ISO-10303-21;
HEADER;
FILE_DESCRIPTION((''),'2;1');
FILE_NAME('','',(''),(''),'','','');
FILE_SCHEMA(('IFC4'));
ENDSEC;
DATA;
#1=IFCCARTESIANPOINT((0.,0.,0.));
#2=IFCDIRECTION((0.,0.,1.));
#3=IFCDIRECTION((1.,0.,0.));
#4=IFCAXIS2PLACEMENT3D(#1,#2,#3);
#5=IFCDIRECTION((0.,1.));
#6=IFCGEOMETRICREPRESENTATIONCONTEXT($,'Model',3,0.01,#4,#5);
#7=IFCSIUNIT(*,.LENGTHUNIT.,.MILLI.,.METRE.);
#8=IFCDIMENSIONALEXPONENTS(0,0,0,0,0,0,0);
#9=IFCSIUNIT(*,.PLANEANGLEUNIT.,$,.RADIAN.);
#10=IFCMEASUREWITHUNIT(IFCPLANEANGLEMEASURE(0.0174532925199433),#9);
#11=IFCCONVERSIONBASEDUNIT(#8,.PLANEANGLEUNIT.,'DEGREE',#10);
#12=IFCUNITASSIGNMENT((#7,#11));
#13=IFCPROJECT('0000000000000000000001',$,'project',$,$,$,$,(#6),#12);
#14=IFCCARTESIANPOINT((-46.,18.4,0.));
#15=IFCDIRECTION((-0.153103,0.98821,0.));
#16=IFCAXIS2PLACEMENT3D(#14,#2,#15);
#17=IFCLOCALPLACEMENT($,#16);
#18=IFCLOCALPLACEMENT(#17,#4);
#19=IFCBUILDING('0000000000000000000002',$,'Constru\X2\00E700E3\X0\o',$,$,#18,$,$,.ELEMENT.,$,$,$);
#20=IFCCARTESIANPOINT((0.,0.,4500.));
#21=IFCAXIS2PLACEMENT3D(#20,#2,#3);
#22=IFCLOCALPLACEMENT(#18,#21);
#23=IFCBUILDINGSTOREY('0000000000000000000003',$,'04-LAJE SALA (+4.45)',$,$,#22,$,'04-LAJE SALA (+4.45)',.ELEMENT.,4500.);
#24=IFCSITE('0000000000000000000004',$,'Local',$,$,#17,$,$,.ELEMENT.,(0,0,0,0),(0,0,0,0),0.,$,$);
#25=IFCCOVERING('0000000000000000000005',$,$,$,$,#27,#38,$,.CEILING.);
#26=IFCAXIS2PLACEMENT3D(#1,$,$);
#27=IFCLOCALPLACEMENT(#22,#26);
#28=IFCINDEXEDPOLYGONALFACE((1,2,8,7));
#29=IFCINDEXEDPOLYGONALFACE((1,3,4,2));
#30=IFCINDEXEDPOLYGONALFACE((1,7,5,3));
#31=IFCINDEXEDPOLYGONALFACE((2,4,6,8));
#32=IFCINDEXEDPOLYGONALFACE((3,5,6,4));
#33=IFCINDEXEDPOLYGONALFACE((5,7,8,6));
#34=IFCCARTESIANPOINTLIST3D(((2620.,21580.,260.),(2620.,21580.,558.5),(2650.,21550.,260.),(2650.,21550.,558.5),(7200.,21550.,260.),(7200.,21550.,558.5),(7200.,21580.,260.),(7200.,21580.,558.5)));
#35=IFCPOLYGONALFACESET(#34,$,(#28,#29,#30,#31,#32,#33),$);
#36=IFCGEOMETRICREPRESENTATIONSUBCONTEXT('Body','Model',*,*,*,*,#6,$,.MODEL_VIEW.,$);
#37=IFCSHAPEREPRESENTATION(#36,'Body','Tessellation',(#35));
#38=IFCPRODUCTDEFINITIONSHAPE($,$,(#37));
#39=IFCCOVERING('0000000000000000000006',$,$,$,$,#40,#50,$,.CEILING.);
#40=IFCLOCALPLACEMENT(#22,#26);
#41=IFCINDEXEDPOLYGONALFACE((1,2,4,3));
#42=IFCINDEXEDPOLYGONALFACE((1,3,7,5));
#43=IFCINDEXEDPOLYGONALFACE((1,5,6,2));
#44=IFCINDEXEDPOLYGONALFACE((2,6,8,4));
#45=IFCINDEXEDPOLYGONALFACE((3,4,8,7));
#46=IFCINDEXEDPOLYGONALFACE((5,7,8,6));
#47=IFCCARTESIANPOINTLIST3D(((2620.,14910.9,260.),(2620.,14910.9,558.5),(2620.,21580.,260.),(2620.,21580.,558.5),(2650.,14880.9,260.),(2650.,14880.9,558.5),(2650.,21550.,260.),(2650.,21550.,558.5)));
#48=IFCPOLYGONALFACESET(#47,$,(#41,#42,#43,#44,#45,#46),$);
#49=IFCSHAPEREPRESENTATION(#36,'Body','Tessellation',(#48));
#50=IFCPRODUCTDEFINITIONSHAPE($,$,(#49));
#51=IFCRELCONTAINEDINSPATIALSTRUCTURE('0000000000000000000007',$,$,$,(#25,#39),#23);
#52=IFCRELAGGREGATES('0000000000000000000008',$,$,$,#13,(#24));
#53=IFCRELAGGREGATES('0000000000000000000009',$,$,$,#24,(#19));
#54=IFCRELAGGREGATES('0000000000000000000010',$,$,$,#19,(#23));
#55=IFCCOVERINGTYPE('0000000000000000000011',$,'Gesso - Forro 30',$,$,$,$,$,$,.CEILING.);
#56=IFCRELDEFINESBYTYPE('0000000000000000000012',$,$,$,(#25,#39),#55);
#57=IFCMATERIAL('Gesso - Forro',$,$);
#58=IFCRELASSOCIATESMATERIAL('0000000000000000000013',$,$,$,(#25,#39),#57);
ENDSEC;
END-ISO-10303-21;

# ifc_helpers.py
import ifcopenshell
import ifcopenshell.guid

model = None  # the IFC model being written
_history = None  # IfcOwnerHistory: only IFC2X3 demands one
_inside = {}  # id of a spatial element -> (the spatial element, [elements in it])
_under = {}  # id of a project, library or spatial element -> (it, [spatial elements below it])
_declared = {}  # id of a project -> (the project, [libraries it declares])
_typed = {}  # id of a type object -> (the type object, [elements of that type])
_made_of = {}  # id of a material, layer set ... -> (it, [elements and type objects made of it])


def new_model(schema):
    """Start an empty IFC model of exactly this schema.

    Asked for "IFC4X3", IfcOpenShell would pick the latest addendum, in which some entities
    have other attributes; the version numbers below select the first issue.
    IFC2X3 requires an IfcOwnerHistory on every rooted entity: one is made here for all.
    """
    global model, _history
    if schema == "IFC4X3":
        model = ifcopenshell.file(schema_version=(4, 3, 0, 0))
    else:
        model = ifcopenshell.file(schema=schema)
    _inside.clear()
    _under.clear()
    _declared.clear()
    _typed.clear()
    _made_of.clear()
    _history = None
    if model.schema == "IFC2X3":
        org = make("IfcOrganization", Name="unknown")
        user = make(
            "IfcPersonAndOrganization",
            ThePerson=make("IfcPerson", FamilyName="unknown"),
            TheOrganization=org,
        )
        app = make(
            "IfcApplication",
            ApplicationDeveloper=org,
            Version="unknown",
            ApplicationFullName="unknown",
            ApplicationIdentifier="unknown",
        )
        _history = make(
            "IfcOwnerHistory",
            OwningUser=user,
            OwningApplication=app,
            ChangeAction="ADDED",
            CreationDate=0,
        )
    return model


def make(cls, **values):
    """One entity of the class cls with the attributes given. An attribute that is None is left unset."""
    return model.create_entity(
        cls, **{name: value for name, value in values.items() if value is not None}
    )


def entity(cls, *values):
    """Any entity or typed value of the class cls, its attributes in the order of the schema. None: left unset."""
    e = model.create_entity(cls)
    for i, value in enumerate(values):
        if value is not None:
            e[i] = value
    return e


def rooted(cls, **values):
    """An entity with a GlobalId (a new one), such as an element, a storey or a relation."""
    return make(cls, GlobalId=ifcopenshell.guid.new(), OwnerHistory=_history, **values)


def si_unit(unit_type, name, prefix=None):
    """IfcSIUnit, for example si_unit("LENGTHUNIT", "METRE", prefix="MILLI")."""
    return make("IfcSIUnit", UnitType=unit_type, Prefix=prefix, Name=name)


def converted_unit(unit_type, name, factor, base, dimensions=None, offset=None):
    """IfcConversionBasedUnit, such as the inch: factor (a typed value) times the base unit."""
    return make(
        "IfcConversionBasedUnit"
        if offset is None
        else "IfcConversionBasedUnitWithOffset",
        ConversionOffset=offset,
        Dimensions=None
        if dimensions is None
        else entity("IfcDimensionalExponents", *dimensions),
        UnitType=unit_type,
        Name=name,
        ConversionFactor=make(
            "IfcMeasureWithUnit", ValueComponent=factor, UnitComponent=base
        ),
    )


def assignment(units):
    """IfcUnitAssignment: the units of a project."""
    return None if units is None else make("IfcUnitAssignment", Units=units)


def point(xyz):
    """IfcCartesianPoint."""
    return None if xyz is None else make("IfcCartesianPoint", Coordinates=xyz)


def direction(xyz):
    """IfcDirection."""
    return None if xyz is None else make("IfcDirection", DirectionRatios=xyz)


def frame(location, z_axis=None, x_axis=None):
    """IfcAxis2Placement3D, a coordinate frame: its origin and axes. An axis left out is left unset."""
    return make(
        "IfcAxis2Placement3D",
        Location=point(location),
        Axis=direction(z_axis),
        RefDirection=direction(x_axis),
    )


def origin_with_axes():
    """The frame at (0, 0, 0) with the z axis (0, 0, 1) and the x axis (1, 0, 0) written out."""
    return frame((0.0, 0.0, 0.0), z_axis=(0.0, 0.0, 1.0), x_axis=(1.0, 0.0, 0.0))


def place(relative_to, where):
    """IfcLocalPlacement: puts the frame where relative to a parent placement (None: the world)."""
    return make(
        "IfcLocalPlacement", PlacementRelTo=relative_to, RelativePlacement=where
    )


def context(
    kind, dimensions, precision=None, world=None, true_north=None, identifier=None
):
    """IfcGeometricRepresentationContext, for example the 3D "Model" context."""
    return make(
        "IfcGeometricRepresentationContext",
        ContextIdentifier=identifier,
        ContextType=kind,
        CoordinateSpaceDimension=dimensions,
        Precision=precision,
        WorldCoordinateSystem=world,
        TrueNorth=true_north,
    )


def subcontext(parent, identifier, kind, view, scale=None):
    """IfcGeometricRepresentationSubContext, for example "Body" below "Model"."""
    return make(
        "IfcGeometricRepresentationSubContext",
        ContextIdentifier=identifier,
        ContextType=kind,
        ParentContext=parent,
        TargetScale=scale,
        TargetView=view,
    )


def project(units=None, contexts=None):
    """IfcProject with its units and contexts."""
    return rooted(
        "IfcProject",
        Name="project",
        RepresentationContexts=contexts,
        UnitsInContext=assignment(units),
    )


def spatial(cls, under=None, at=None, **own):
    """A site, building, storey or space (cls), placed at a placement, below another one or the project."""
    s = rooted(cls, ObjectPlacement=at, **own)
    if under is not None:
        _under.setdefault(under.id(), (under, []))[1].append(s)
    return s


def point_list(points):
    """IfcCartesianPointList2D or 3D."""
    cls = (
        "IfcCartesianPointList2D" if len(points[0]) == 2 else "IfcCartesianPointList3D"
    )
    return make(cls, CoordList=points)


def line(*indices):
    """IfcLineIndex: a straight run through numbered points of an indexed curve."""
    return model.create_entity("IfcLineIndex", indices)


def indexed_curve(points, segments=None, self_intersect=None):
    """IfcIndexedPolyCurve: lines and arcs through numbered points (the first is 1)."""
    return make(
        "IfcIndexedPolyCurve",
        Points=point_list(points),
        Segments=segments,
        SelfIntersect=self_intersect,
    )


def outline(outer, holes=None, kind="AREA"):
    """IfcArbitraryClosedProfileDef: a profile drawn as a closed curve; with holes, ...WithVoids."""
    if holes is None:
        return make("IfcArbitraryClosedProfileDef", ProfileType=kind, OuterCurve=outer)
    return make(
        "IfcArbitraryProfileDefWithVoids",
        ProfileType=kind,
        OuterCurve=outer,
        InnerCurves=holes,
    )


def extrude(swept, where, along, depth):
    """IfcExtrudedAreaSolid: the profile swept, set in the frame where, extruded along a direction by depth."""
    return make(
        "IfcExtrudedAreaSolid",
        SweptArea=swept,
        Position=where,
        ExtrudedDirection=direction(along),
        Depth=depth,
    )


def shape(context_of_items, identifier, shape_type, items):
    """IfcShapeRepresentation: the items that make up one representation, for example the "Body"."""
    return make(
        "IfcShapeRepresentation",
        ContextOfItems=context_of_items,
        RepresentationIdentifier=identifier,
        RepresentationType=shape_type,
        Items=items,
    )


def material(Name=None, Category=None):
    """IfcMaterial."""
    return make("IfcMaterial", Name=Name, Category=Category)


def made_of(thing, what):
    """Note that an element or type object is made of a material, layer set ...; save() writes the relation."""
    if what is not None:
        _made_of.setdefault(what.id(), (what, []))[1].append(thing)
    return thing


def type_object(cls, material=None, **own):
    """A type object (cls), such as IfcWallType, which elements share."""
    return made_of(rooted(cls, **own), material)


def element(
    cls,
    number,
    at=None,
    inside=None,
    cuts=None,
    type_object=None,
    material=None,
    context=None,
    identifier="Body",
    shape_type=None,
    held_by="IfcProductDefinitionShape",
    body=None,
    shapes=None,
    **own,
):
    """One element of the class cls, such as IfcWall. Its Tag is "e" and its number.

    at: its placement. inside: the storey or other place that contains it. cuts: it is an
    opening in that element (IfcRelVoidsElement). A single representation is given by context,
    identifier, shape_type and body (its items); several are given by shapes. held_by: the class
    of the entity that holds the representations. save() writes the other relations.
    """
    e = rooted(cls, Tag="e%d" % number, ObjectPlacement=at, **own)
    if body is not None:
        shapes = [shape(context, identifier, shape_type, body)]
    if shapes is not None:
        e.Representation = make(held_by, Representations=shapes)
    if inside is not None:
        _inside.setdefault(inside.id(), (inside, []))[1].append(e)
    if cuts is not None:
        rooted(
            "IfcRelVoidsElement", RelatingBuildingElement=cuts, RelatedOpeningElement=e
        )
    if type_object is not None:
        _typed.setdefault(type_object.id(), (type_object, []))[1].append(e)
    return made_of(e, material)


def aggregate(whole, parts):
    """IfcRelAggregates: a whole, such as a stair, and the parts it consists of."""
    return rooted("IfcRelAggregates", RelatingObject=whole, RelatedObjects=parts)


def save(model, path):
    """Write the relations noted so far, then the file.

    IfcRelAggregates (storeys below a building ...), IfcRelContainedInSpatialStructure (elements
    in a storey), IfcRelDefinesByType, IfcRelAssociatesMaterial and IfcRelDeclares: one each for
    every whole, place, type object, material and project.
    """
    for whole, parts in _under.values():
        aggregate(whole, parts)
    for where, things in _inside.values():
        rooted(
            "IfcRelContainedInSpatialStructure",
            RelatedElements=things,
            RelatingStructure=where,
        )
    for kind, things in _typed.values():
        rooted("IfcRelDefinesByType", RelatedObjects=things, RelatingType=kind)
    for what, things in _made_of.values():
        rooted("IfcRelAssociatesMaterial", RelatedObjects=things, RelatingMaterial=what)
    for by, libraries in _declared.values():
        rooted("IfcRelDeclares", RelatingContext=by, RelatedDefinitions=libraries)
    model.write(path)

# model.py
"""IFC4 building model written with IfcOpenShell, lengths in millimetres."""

from ifc_helpers import new_model, entity, si_unit, converted_unit, direction, frame, origin_with_axes, place, context, subcontext, project, spatial, line, indexed_curve, outline, extrude, material, type_object, element, save


model = new_model("IFC4")

# Units and contexts
model_context = context("Model", 3, precision=0.01, world=origin_with_axes(), true_north=direction((0.0, 1.0)))
body_context = subcontext(model_context, "Body", "Model", "MODEL_VIEW")
ifc_project = project(units=[si_unit("LENGTHUNIT", "METRE", prefix="MILLI"), converted_unit("PLANEANGLEUNIT", "DEGREE", entity("IfcPlaneAngleMeasure", 0.0174532925199433), si_unit("PLANEANGLEUNIT", "RADIAN"), dimensions=[0, 0, 0, 0, 0, 0, 0])], contexts=[model_context])

# Site, building, storey
site_placement = place(None, frame((-46.0, 18.4, 0.0), z_axis=(0.0, 0.0, 1.0), x_axis=(-0.153103, 0.98821, 0.0)))
site = spatial("IfcSite", under=ifc_project, at=site_placement, Name="Local", CompositionType="ELEMENT", RefLatitude=(0, 0, 0, 0), RefLongitude=(0, 0, 0, 0), RefElevation=0.0)
building_placement = place(site_placement, origin_with_axes())
building = spatial("IfcBuilding", under=site, at=building_placement, Name="Construção", CompositionType="ELEMENT")
storey_placement = place(building_placement, frame((0.0, 0.0, 4500.0), z_axis=(0.0, 0.0, 1.0), x_axis=(1.0, 0.0, 0.0)))
storey = spatial("IfcBuildingStorey", under=building, at=storey_placement, Name="04-LAJE SALA (+4.45)", LongName="04-LAJE SALA (+4.45)", CompositionType="ELEMENT", Elevation=4500.0)

# Coverings
ifc_material = material(Name="Gesso - Forro")
covering_type = type_object("IfcCoveringType", Name="Gesso - Forro 30", PredefinedType="CEILING")
covering_1_placement = place(storey_placement, frame((2650.0, 21550.0, 260.0), z_axis=(0.0, 0.0, 1.0), x_axis=(1.0, 0.0, 0.0)))
element("IfcCovering", 1, at=covering_1_placement, inside=storey, type_object=covering_type, material=ifc_material, PredefinedType="CEILING", context=body_context, shape_type="SweptSolid", body=[
    extrude(outline(indexed_curve([(0.0, 0.0), (4550.0, 0.0), (4550.0, 30.0), (-30.0, 30.0)], segments=[line(1, 2, 3, 4, 1)])), origin_with_axes(), (0.0, 0.0, 1.0), 298.5),
])
covering_2_placement = place(storey_placement, frame((2650.0, 14880.9, 260.0), z_axis=(0.0, 0.0, 1.0), x_axis=(0.0, 1.0, 0.0)))
element("IfcCovering", 2, at=covering_2_placement, inside=storey, type_object=covering_type, material=ifc_material, PredefinedType="CEILING", context=body_context, shape_type="SweptSolid", body=[
    extrude(outline(indexed_curve([(0.0, 0.0), (6669.1, 0.0), (6699.1, 30.0), (30.0, 30.0)], segments=[line(1, 2, 3, 4, 1)])), origin_with_axes(), (0.0, 0.0, 1.0), 298.5),
])

save(model, "model.ifc")
